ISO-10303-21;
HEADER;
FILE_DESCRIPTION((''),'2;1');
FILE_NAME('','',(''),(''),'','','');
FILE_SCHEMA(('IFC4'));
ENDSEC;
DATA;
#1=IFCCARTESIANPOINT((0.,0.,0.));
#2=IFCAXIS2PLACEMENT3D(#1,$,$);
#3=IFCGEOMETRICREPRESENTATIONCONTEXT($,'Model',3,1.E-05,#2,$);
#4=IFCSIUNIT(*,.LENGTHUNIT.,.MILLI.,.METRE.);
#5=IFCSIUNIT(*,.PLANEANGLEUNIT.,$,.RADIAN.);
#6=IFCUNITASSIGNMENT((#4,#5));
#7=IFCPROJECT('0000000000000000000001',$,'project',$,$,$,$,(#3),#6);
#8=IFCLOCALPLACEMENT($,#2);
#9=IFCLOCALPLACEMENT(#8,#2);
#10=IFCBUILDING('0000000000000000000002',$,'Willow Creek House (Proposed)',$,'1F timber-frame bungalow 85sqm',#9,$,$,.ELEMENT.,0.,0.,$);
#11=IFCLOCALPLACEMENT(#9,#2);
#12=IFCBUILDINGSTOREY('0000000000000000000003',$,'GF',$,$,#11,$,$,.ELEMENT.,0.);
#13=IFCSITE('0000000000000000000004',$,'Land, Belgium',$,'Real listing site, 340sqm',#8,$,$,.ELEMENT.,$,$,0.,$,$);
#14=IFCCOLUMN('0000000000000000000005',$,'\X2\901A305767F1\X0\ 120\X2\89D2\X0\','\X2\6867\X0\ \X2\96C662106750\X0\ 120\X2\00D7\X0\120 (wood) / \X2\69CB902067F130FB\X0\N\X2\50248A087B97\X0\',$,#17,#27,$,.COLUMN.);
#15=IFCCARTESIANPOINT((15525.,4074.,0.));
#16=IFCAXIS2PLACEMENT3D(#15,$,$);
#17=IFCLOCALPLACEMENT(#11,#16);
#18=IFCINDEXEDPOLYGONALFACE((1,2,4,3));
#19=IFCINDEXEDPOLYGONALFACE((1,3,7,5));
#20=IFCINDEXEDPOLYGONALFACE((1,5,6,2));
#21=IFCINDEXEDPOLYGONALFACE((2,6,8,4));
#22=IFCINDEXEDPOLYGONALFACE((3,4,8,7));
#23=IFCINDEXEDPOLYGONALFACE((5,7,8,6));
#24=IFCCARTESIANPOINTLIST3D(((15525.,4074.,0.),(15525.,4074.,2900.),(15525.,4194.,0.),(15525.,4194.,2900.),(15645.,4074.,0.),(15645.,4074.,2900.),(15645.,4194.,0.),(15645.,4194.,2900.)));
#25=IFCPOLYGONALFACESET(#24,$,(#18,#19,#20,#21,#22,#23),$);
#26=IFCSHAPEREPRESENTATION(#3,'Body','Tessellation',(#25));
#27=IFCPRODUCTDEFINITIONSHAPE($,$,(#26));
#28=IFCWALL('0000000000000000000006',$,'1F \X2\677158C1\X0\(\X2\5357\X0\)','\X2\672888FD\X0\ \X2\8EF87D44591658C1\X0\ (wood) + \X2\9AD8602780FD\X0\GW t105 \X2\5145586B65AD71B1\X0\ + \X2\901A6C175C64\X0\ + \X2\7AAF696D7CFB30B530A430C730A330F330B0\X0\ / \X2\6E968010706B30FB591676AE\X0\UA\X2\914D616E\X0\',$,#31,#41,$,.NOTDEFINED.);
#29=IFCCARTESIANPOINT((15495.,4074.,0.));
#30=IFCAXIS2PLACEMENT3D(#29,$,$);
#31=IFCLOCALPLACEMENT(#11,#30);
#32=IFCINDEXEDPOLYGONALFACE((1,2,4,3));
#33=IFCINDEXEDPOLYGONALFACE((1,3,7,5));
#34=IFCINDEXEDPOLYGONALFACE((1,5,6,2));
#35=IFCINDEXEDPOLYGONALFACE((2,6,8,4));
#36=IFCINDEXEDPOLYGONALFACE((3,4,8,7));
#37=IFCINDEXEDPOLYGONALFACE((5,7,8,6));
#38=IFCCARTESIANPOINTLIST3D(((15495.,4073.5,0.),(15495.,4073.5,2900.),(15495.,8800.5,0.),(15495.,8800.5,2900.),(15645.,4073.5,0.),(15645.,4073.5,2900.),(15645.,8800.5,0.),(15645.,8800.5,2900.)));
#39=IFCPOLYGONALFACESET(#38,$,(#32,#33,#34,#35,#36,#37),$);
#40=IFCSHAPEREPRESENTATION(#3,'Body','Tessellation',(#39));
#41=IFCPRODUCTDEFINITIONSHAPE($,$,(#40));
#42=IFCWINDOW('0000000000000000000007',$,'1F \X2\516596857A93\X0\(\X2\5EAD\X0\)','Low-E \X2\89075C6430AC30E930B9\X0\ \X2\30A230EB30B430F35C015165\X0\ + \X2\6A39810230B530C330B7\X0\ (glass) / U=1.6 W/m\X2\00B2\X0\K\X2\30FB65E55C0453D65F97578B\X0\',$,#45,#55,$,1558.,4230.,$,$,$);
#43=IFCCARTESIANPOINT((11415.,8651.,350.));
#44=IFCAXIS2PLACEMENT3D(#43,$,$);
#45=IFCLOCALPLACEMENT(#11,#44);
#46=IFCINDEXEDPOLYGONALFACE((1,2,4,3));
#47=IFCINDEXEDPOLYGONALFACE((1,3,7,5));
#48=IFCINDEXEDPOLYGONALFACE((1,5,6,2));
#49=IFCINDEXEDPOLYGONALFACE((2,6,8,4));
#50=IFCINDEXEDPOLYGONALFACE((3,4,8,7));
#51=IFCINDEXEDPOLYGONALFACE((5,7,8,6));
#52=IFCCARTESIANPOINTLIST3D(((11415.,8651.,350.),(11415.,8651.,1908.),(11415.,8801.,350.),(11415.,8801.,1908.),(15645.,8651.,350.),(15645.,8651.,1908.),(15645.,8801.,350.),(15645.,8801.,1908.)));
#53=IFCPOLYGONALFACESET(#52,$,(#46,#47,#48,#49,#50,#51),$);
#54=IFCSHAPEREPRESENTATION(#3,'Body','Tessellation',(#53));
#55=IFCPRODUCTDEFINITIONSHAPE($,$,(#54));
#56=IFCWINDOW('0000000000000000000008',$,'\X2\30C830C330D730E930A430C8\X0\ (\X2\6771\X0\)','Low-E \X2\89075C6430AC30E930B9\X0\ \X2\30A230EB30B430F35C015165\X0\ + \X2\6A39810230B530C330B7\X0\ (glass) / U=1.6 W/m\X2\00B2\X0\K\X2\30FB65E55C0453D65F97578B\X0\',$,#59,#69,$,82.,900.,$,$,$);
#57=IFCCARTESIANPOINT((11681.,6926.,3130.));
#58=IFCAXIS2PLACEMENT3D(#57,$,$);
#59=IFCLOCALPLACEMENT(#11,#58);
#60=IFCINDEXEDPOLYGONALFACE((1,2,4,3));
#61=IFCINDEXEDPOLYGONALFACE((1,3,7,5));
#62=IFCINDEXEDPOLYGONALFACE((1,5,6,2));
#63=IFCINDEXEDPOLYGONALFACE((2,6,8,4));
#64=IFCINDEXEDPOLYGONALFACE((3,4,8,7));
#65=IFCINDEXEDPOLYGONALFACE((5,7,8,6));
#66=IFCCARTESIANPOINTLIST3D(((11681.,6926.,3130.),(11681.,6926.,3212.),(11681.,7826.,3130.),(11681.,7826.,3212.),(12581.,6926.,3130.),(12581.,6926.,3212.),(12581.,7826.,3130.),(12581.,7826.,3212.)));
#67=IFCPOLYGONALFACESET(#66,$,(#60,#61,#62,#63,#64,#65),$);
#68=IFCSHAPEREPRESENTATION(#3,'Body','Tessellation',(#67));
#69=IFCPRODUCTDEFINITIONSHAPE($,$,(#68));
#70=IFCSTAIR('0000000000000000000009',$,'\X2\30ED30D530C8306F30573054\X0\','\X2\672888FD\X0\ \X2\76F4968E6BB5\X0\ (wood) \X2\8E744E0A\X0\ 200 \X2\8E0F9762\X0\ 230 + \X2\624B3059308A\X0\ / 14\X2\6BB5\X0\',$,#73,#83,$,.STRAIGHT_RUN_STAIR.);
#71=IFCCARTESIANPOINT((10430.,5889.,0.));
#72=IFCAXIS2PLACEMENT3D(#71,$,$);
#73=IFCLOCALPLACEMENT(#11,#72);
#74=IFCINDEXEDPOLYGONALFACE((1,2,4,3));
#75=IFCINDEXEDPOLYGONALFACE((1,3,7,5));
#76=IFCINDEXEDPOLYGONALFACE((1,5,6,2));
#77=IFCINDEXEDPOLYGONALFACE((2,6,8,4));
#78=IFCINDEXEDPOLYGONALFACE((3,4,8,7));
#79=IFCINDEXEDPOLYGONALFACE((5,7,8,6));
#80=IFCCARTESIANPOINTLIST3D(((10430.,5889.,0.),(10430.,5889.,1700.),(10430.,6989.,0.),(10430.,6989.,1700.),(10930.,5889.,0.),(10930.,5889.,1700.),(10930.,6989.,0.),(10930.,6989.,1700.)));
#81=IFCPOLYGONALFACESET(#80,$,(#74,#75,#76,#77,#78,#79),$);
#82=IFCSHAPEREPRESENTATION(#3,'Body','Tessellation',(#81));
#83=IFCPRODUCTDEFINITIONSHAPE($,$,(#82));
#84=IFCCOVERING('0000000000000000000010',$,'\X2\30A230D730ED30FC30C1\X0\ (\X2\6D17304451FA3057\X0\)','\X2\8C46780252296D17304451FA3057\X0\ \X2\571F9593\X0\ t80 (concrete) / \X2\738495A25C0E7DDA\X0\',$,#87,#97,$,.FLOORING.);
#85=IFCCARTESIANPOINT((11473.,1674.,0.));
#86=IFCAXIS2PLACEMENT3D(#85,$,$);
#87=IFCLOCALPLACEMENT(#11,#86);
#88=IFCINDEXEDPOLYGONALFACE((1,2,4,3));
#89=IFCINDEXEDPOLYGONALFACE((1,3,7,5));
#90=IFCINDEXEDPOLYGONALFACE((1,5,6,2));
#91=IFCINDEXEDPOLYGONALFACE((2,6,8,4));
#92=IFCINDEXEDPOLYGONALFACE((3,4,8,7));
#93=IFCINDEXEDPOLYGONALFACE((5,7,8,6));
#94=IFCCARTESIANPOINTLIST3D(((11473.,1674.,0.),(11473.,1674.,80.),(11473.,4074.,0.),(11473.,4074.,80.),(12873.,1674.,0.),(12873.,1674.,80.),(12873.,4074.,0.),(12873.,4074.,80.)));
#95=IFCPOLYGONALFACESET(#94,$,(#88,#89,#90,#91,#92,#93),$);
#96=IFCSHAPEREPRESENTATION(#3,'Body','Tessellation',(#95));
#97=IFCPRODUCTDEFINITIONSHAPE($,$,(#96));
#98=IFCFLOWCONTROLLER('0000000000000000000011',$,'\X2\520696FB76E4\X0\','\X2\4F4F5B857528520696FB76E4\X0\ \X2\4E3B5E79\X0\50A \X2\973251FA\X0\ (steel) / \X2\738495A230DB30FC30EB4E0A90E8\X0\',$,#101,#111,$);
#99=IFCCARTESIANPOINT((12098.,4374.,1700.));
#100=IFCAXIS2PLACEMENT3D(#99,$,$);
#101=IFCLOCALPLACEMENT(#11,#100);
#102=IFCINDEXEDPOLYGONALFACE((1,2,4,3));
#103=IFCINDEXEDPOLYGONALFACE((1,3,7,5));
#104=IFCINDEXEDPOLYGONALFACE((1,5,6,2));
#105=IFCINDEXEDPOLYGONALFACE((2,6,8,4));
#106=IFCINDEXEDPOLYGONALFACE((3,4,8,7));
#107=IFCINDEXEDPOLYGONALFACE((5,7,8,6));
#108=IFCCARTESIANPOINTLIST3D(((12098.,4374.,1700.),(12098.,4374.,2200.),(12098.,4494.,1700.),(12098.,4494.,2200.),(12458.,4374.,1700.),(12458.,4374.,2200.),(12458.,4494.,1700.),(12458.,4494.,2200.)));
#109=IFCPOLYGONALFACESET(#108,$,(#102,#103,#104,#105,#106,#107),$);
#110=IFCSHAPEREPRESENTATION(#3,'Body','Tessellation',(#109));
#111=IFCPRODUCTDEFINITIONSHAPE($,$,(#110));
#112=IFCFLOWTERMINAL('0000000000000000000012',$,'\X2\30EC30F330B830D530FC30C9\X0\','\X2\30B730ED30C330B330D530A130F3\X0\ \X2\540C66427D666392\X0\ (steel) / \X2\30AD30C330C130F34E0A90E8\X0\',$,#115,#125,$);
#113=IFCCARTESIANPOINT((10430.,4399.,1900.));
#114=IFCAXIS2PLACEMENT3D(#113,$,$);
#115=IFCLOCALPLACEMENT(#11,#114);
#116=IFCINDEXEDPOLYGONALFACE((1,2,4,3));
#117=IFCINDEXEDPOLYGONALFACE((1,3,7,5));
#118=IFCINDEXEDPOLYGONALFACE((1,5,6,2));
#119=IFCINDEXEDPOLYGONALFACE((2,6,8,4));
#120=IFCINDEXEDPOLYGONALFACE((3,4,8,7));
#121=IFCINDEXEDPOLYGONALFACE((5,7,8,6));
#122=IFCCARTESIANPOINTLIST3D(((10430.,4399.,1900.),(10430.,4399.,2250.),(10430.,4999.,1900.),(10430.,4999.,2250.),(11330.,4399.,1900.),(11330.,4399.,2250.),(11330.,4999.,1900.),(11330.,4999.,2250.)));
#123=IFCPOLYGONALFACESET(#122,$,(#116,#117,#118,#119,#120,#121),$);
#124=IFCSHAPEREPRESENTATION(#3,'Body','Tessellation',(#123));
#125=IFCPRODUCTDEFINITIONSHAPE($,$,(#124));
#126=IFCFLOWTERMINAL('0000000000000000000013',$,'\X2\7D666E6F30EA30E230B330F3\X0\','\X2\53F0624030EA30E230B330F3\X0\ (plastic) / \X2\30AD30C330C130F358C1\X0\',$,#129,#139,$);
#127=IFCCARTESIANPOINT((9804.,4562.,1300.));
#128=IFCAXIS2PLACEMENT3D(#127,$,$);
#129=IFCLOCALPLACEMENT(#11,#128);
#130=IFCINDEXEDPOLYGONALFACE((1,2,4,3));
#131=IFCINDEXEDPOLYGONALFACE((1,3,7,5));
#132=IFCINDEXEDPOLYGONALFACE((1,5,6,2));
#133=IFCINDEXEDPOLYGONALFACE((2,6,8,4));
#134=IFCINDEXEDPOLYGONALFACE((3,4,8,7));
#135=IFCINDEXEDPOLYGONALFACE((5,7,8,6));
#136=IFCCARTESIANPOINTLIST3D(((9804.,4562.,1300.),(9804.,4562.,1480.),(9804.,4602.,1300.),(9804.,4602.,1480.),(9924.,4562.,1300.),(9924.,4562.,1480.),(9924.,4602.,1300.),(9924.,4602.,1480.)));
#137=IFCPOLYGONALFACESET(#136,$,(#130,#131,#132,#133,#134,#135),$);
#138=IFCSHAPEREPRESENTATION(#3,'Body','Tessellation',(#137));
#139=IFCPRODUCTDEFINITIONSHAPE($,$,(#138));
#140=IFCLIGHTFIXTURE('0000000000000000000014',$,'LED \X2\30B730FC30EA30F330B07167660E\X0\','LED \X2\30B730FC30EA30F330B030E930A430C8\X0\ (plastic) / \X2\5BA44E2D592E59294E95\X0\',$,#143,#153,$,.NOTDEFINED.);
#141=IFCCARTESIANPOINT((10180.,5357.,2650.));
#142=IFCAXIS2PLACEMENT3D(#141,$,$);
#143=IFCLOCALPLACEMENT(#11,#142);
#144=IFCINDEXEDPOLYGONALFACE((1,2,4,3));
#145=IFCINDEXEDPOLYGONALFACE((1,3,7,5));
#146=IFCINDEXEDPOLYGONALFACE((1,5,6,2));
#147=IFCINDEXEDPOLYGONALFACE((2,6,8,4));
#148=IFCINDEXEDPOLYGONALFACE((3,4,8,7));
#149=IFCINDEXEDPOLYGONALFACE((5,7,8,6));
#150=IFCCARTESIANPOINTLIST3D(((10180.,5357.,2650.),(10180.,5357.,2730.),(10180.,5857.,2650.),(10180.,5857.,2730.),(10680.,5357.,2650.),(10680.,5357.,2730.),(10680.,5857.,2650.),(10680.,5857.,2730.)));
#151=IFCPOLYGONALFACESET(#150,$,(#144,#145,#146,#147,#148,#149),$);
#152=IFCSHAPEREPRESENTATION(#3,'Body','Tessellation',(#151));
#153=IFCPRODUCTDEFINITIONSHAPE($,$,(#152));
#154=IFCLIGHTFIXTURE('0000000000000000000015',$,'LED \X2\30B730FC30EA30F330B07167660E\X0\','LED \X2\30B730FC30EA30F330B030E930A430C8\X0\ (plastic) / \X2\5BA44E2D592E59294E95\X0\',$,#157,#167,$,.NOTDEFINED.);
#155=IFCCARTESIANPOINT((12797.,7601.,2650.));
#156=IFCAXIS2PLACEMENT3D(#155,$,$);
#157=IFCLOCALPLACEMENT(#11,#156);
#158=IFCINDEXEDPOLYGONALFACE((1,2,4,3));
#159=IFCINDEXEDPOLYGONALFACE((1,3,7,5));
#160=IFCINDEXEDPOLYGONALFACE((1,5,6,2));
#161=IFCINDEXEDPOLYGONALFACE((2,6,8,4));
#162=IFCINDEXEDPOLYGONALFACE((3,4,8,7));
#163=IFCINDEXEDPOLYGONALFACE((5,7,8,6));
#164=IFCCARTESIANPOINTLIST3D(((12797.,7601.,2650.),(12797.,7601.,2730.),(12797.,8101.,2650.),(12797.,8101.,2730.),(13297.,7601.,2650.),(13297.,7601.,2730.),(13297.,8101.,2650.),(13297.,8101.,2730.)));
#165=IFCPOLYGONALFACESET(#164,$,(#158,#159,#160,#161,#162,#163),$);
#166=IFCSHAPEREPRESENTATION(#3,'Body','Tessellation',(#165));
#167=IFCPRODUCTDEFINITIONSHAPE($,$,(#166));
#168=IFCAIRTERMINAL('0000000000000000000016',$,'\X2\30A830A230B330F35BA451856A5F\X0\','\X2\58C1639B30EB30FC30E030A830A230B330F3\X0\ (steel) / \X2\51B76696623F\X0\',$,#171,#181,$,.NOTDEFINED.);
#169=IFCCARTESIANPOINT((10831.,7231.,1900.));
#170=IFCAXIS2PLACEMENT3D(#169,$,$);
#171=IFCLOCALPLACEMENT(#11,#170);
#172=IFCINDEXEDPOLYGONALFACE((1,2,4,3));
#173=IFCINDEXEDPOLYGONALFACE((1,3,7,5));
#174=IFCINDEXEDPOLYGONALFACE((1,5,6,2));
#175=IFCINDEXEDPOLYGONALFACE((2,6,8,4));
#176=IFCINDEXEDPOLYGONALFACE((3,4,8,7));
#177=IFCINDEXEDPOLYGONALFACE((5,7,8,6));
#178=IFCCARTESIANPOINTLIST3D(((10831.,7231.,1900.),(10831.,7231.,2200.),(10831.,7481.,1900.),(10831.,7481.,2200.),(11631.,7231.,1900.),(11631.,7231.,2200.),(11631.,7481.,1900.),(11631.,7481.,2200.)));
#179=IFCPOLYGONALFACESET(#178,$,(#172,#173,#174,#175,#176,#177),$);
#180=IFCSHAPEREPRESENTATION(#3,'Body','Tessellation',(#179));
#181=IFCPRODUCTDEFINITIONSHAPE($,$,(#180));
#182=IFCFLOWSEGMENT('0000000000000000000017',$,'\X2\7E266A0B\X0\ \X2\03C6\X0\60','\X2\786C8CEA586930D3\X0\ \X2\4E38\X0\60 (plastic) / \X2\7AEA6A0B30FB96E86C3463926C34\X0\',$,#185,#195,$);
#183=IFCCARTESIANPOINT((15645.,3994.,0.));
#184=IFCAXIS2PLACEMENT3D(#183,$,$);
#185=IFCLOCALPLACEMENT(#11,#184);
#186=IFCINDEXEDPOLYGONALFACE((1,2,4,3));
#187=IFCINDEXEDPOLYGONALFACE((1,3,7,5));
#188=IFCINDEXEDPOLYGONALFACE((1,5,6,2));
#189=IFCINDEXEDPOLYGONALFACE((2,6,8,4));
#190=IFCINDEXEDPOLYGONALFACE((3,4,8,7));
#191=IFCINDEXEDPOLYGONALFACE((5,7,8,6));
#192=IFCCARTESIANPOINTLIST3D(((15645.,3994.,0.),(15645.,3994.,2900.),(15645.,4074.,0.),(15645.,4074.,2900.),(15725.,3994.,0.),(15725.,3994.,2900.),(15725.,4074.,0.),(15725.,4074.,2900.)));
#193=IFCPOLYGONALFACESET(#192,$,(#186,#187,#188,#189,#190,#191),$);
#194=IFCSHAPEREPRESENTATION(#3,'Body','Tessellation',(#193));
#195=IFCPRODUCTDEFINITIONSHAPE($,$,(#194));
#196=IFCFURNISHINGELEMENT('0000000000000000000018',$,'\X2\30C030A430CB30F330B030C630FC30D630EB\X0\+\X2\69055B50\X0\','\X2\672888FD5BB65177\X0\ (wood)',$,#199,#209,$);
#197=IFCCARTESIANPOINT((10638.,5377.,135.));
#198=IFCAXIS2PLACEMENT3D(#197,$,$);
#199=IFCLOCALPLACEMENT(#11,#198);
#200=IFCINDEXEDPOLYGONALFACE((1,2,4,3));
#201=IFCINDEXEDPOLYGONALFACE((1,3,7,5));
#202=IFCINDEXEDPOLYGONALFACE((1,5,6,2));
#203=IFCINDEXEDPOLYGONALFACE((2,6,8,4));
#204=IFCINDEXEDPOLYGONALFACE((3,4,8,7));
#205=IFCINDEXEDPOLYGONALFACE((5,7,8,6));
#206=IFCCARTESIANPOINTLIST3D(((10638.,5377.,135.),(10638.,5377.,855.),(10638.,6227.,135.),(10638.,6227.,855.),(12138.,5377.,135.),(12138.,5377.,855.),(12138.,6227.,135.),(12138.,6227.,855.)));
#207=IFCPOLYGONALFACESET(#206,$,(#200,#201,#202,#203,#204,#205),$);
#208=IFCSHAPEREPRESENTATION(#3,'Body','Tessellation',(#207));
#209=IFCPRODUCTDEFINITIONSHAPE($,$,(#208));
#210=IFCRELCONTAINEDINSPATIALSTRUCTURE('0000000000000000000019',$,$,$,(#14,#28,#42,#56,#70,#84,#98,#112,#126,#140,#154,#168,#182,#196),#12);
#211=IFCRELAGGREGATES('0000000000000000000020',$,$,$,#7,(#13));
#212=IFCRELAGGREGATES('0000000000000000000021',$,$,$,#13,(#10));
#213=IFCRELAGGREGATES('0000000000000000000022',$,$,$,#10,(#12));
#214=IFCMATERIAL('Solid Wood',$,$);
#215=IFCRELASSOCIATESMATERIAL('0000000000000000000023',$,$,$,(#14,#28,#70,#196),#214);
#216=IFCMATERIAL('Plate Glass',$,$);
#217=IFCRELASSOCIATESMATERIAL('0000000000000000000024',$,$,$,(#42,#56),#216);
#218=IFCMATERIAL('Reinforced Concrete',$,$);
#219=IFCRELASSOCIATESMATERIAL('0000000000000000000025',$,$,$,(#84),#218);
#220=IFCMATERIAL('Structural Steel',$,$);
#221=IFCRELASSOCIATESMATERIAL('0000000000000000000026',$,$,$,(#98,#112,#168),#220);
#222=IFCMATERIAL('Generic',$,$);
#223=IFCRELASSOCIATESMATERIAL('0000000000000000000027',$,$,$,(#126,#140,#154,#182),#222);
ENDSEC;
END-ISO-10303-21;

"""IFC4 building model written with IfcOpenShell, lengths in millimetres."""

from ifc_helpers import new_model, si_unit, frame, frame_2d, origin, place, context, project, spatial, rectangle, extrude, material, element, fill, save


model = new_model("IFC4")

# Units and contexts
model_context = context("Model", 3, precision=1e-05, world=origin())
ifc_project = project(units=[si_unit("LENGTHUNIT", "METRE", prefix="MILLI"), si_unit("PLANEANGLEUNIT", "RADIAN")], contexts=[model_context])

# Site, building, storey
site_placement = place(None, origin())
site = spatial("IfcSite", under=ifc_project, at=site_placement, Name="Land, Belgium", ObjectType="Real listing site, 340sqm", CompositionType="ELEMENT", RefElevation=0.0)
building_placement = place(site_placement, origin())
building = spatial("IfcBuilding", under=site, at=building_placement, Name="Willow Creek House (Proposed)", ObjectType="1F timber-frame bungalow 85sqm", CompositionType="ELEMENT", ElevationOfRefHeight=0.0, ElevationOfTerrain=0.0)
storey_placement = place(building_placement, origin())
storey = spatial("IfcBuildingStorey", under=building, at=storey_placement, Name="GF", CompositionType="ELEMENT", Elevation=0.0)

# Column
ifc_material_1 = material(Name="Solid Wood")
column_1_placement = place(storey_placement, frame((15525.0, 4074.0, 0.0)))
element("IfcColumn", 1, at=column_1_placement, inside=storey, material=ifc_material_1, Name="通し柱 120角", Description="桧 集成材 120×120 (wood) / 構造柱・N値計算", PredefinedType="COLUMN", context=model_context, shape_type="SweptSolid", body=[
    extrude(rectangle(XDim=120.0, YDim=120.0, at=frame_2d((60.0, 60.0))), frame((15525.0, 4074.0, 0.0)), (0.0, 0.0, 1.0), 2900.0),
])

# Wall, opening, window
wall_1_placement = place(storey_placement, frame((15495.0, 4074.0, 0.0)))
wall_1 = element("IfcWall", 2, at=wall_1_placement, inside=storey, material=ifc_material_1, Name="1F 東壁(南)", Description="木製 軸組外壁 (wood) + 高性能GW t105 充填断熱 + 通気層 + 窯業系サイディング / 準耐火・外皮UA配慮", PredefinedType="NOTDEFINED", context=model_context, shape_type="SweptSolid", body=[
    extrude(rectangle(XDim=150.0, YDim=4727.0, at=frame_2d((75.0, 2363.0))), frame((15495.0, 4074.0, 0.0)), (0.0, 0.0, 1.0), 2900.0),
])
opening_1_placement = place(storey_placement, frame((11415.0, 8651.0, 350.0)))
opening_1 = element("IfcOpeningElement", 3, at=opening_1_placement, cuts=wall_1, PredefinedType="NOTDEFINED", context=model_context, shape_type="SweptSolid", body=[
    extrude(rectangle(XDim=4230.0, YDim=150.0, at=frame_2d((2115.0, 75.0))), frame((11415.0, 8651.0, 350.0)), (0.0, 0.0, 1.0), 1558.0),
])
ifc_material_2 = material(Name="Plate Glass")
window_1_placement = place(storey_placement, frame((11415.0, 8651.0, 350.0)))
window_1 = element("IfcWindow", 4, at=window_1_placement, inside=storey, material=ifc_material_2, Name="1F 入隅窓(庭)", Description="Low-E 複層ガラス アルゴン封入 + 樹脂サッシ (glass) / U=1.6 W/m²K・日射取得型", OverallHeight=1558.0, OverallWidth=4230.0, context=model_context, shape_type="SweptSolid", body=[
    extrude(rectangle(XDim=4230.0, YDim=150.0, at=frame_2d((2115.0, 75.0))), frame((11415.0, 8651.0, 350.0)), (0.0, 0.0, 1.0), 1558.0),
])
fill(opening_1, window_1)

# Window
window_2_placement = place(storey_placement, frame((11681.0, 6926.0, 3130.0)))
element("IfcWindow", 5, at=window_2_placement, inside=storey, material=ifc_material_2, Name="トップライト (東)", Description="Low-E 複層ガラス アルゴン封入 + 樹脂サッシ (glass) / U=1.6 W/m²K・日射取得型", OverallHeight=82.0, OverallWidth=900.0, context=model_context, shape_type="SweptSolid", body=[
    extrude(rectangle(XDim=900.0, YDim=900.0, at=frame_2d((450.0, 450.0))), frame((11681.0, 6926.0, 3130.0)), (0.0, 0.0, 1.0), 82.0),
])

# Stair
stair_placement = place(storey_placement, frame((10430.0, 5889.0, 0.0)))
element("IfcStair", 6, at=stair_placement, inside=storey, material=ifc_material_1, Name="ロフトはしご", Description="木製 直階段 (wood) 蹴上 200 踏面 230 + 手すり / 14段", PredefinedType="STRAIGHT_RUN_STAIR", context=model_context, shape_type="SweptSolid", body=[
    extrude(rectangle(XDim=500.0, YDim=1100.0, at=frame_2d((250.0, 550.0))), frame((10430.0, 5889.0, 0.0)), (0.0, 0.0, 1.0), 1700.0),
])

# Covering
ifc_material_3 = material(Name="Reinforced Concrete")
covering_placement = place(storey_placement, frame((11473.0, 1674.0, 0.0)))
element("IfcCovering", 7, at=covering_placement, inside=storey, material=ifc_material_3, Name="アプローチ (洗い出し)", Description="豆砂利洗い出し 土間 t80 (concrete) / 玄関導線", PredefinedType="FLOORING", context=model_context, shape_type="SweptSolid", body=[
    extrude(rectangle(XDim=1400.0, YDim=2400.0, at=frame_2d((700.0, 1200.0))), frame((11473.0, 1674.0, 0.0)), (0.0, 0.0, 1.0), 80.0),
])

# Flow controller
ifc_material_4 = material(Name="Structural Steel")
flow_controller_placement = place(storey_placement, frame((12098.0, 4374.0, 1700.0)))
element("IfcFlowController", 8, at=flow_controller_placement, inside=storey, material=ifc_material_4, Name="分電盤", Description="住宅用分電盤 主幹50A 露出 (steel) / 玄関ホール上部", context=model_context, shape_type="SweptSolid", body=[
    extrude(rectangle(XDim=360.0, YDim=120.0, at=frame_2d((180.0, 60.0))), frame((12098.0, 4374.0, 1700.0)), (0.0, 0.0, 1.0), 500.0),
])

# Flow terminals
flow_terminal_1_placement = place(storey_placement, frame((10430.0, 4399.0, 1900.0)))
element("IfcFlowTerminal", 9, at=flow_terminal_1_placement, inside=storey, material=ifc_material_4, Name="レンジフード", Description="シロッコファン 同時給排 (steel) / キッチン上部", context=model_context, shape_type="SweptSolid", body=[
    extrude(rectangle(XDim=900.0, YDim=600.0, at=frame_2d((450.0, 300.0))), frame((10430.0, 4399.0, 1900.0)), (0.0, 0.0, 1.0), 350.0),
])
ifc_material_5 = material(Name="Generic")
flow_terminal_2_placement = place(storey_placement, frame((9804.0, 4562.0, 1300.0)))
element("IfcFlowTerminal", 10, at=flow_terminal_2_placement, inside=storey, material=ifc_material_5, Name="給湯リモコン", Description="台所リモコン (plastic) / キッチン壁", context=model_context, shape_type="SweptSolid", body=[
    extrude(rectangle(XDim=120.0, YDim=40.0, at=frame_2d((60.0, 20.0))), frame((9804.0, 4562.0, 1300.0)), (0.0, 0.0, 1.0), 180.0),
])

# Light fixtures
light_fixture_1_placement = place(storey_placement, frame((10180.0, 5357.0, 2650.0)))
element("IfcLightFixture", 11, at=light_fixture_1_placement, inside=storey, material=ifc_material_5, Name="LED シーリング照明", Description="LED シーリングライト (plastic) / 室中央天井", PredefinedType="NOTDEFINED", context=model_context, shape_type="SweptSolid", body=[
    extrude(rectangle(XDim=500.0, YDim=500.0, at=frame_2d((250.0, 250.0))), frame((10180.0, 5357.0, 2650.0)), (0.0, 0.0, 1.0), 80.0),
])
light_fixture_2_placement = place(storey_placement, frame((12797.0, 7601.0, 2650.0)))
element("IfcLightFixture", 12, at=light_fixture_2_placement, inside=storey, material=ifc_material_5, Name="LED シーリング照明", Description="LED シーリングライト (plastic) / 室中央天井", PredefinedType="NOTDEFINED", context=model_context, shape_type="SweptSolid", body=[
    extrude(rectangle(XDim=500.0, YDim=500.0, at=frame_2d((250.0, 250.0))), frame((12797.0, 7601.0, 2650.0)), (0.0, 0.0, 1.0), 80.0),
])

# Air terminal
air_terminal_placement = place(storey_placement, frame((10831.0, 7231.0, 1900.0)))
element("IfcAirTerminal", 13, at=air_terminal_placement, inside=storey, material=ifc_material_4, Name="エアコン室内機", Description="壁掛ルームエアコン (steel) / 冷暖房", PredefinedType="NOTDEFINED", context=model_context, shape_type="SweptSolid", body=[
    extrude(rectangle(XDim=800.0, YDim=250.0, at=frame_2d((400.0, 125.0))), frame((10831.0, 7231.0, 1900.0)), (0.0, 0.0, 1.0), 300.0),
])

# Flow segment
flow_segment_placement = place(storey_placement, frame((15645.0, 3994.0, 0.0)))
element("IfcFlowSegment", 14, at=flow_segment_placement, inside=storey, material=ifc_material_5, Name="縦樋 φ60", Description="硬質塩ビ 丸60 (plastic) / 竪樋・雨水排水", context=model_context, shape_type="SweptSolid", body=[
    extrude(rectangle(XDim=80.0, YDim=80.0, at=frame_2d((40.0, 40.0))), frame((15645.0, 3994.0, 0.0)), (0.0, 0.0, 1.0), 2900.0),
])

# Furnishing element
furnishing_1_placement = place(storey_placement, frame((10638.0, 5377.0, 135.0)))
element("IfcFurnishingElement", 15, at=furnishing_1_placement, inside=storey, material=ifc_material_1, Name="ダイニングテーブル+椅子", Description="木製家具 (wood)", context=model_context, shape_type="SweptSolid", body=[
    extrude(rectangle(XDim=1500.0, YDim=850.0, at=frame_2d((750.0, 425.0))), frame((10638.0, 5377.0, 135.0)), (0.0, 0.0, 1.0), 720.0),
])

save(model, "model.ifc")
